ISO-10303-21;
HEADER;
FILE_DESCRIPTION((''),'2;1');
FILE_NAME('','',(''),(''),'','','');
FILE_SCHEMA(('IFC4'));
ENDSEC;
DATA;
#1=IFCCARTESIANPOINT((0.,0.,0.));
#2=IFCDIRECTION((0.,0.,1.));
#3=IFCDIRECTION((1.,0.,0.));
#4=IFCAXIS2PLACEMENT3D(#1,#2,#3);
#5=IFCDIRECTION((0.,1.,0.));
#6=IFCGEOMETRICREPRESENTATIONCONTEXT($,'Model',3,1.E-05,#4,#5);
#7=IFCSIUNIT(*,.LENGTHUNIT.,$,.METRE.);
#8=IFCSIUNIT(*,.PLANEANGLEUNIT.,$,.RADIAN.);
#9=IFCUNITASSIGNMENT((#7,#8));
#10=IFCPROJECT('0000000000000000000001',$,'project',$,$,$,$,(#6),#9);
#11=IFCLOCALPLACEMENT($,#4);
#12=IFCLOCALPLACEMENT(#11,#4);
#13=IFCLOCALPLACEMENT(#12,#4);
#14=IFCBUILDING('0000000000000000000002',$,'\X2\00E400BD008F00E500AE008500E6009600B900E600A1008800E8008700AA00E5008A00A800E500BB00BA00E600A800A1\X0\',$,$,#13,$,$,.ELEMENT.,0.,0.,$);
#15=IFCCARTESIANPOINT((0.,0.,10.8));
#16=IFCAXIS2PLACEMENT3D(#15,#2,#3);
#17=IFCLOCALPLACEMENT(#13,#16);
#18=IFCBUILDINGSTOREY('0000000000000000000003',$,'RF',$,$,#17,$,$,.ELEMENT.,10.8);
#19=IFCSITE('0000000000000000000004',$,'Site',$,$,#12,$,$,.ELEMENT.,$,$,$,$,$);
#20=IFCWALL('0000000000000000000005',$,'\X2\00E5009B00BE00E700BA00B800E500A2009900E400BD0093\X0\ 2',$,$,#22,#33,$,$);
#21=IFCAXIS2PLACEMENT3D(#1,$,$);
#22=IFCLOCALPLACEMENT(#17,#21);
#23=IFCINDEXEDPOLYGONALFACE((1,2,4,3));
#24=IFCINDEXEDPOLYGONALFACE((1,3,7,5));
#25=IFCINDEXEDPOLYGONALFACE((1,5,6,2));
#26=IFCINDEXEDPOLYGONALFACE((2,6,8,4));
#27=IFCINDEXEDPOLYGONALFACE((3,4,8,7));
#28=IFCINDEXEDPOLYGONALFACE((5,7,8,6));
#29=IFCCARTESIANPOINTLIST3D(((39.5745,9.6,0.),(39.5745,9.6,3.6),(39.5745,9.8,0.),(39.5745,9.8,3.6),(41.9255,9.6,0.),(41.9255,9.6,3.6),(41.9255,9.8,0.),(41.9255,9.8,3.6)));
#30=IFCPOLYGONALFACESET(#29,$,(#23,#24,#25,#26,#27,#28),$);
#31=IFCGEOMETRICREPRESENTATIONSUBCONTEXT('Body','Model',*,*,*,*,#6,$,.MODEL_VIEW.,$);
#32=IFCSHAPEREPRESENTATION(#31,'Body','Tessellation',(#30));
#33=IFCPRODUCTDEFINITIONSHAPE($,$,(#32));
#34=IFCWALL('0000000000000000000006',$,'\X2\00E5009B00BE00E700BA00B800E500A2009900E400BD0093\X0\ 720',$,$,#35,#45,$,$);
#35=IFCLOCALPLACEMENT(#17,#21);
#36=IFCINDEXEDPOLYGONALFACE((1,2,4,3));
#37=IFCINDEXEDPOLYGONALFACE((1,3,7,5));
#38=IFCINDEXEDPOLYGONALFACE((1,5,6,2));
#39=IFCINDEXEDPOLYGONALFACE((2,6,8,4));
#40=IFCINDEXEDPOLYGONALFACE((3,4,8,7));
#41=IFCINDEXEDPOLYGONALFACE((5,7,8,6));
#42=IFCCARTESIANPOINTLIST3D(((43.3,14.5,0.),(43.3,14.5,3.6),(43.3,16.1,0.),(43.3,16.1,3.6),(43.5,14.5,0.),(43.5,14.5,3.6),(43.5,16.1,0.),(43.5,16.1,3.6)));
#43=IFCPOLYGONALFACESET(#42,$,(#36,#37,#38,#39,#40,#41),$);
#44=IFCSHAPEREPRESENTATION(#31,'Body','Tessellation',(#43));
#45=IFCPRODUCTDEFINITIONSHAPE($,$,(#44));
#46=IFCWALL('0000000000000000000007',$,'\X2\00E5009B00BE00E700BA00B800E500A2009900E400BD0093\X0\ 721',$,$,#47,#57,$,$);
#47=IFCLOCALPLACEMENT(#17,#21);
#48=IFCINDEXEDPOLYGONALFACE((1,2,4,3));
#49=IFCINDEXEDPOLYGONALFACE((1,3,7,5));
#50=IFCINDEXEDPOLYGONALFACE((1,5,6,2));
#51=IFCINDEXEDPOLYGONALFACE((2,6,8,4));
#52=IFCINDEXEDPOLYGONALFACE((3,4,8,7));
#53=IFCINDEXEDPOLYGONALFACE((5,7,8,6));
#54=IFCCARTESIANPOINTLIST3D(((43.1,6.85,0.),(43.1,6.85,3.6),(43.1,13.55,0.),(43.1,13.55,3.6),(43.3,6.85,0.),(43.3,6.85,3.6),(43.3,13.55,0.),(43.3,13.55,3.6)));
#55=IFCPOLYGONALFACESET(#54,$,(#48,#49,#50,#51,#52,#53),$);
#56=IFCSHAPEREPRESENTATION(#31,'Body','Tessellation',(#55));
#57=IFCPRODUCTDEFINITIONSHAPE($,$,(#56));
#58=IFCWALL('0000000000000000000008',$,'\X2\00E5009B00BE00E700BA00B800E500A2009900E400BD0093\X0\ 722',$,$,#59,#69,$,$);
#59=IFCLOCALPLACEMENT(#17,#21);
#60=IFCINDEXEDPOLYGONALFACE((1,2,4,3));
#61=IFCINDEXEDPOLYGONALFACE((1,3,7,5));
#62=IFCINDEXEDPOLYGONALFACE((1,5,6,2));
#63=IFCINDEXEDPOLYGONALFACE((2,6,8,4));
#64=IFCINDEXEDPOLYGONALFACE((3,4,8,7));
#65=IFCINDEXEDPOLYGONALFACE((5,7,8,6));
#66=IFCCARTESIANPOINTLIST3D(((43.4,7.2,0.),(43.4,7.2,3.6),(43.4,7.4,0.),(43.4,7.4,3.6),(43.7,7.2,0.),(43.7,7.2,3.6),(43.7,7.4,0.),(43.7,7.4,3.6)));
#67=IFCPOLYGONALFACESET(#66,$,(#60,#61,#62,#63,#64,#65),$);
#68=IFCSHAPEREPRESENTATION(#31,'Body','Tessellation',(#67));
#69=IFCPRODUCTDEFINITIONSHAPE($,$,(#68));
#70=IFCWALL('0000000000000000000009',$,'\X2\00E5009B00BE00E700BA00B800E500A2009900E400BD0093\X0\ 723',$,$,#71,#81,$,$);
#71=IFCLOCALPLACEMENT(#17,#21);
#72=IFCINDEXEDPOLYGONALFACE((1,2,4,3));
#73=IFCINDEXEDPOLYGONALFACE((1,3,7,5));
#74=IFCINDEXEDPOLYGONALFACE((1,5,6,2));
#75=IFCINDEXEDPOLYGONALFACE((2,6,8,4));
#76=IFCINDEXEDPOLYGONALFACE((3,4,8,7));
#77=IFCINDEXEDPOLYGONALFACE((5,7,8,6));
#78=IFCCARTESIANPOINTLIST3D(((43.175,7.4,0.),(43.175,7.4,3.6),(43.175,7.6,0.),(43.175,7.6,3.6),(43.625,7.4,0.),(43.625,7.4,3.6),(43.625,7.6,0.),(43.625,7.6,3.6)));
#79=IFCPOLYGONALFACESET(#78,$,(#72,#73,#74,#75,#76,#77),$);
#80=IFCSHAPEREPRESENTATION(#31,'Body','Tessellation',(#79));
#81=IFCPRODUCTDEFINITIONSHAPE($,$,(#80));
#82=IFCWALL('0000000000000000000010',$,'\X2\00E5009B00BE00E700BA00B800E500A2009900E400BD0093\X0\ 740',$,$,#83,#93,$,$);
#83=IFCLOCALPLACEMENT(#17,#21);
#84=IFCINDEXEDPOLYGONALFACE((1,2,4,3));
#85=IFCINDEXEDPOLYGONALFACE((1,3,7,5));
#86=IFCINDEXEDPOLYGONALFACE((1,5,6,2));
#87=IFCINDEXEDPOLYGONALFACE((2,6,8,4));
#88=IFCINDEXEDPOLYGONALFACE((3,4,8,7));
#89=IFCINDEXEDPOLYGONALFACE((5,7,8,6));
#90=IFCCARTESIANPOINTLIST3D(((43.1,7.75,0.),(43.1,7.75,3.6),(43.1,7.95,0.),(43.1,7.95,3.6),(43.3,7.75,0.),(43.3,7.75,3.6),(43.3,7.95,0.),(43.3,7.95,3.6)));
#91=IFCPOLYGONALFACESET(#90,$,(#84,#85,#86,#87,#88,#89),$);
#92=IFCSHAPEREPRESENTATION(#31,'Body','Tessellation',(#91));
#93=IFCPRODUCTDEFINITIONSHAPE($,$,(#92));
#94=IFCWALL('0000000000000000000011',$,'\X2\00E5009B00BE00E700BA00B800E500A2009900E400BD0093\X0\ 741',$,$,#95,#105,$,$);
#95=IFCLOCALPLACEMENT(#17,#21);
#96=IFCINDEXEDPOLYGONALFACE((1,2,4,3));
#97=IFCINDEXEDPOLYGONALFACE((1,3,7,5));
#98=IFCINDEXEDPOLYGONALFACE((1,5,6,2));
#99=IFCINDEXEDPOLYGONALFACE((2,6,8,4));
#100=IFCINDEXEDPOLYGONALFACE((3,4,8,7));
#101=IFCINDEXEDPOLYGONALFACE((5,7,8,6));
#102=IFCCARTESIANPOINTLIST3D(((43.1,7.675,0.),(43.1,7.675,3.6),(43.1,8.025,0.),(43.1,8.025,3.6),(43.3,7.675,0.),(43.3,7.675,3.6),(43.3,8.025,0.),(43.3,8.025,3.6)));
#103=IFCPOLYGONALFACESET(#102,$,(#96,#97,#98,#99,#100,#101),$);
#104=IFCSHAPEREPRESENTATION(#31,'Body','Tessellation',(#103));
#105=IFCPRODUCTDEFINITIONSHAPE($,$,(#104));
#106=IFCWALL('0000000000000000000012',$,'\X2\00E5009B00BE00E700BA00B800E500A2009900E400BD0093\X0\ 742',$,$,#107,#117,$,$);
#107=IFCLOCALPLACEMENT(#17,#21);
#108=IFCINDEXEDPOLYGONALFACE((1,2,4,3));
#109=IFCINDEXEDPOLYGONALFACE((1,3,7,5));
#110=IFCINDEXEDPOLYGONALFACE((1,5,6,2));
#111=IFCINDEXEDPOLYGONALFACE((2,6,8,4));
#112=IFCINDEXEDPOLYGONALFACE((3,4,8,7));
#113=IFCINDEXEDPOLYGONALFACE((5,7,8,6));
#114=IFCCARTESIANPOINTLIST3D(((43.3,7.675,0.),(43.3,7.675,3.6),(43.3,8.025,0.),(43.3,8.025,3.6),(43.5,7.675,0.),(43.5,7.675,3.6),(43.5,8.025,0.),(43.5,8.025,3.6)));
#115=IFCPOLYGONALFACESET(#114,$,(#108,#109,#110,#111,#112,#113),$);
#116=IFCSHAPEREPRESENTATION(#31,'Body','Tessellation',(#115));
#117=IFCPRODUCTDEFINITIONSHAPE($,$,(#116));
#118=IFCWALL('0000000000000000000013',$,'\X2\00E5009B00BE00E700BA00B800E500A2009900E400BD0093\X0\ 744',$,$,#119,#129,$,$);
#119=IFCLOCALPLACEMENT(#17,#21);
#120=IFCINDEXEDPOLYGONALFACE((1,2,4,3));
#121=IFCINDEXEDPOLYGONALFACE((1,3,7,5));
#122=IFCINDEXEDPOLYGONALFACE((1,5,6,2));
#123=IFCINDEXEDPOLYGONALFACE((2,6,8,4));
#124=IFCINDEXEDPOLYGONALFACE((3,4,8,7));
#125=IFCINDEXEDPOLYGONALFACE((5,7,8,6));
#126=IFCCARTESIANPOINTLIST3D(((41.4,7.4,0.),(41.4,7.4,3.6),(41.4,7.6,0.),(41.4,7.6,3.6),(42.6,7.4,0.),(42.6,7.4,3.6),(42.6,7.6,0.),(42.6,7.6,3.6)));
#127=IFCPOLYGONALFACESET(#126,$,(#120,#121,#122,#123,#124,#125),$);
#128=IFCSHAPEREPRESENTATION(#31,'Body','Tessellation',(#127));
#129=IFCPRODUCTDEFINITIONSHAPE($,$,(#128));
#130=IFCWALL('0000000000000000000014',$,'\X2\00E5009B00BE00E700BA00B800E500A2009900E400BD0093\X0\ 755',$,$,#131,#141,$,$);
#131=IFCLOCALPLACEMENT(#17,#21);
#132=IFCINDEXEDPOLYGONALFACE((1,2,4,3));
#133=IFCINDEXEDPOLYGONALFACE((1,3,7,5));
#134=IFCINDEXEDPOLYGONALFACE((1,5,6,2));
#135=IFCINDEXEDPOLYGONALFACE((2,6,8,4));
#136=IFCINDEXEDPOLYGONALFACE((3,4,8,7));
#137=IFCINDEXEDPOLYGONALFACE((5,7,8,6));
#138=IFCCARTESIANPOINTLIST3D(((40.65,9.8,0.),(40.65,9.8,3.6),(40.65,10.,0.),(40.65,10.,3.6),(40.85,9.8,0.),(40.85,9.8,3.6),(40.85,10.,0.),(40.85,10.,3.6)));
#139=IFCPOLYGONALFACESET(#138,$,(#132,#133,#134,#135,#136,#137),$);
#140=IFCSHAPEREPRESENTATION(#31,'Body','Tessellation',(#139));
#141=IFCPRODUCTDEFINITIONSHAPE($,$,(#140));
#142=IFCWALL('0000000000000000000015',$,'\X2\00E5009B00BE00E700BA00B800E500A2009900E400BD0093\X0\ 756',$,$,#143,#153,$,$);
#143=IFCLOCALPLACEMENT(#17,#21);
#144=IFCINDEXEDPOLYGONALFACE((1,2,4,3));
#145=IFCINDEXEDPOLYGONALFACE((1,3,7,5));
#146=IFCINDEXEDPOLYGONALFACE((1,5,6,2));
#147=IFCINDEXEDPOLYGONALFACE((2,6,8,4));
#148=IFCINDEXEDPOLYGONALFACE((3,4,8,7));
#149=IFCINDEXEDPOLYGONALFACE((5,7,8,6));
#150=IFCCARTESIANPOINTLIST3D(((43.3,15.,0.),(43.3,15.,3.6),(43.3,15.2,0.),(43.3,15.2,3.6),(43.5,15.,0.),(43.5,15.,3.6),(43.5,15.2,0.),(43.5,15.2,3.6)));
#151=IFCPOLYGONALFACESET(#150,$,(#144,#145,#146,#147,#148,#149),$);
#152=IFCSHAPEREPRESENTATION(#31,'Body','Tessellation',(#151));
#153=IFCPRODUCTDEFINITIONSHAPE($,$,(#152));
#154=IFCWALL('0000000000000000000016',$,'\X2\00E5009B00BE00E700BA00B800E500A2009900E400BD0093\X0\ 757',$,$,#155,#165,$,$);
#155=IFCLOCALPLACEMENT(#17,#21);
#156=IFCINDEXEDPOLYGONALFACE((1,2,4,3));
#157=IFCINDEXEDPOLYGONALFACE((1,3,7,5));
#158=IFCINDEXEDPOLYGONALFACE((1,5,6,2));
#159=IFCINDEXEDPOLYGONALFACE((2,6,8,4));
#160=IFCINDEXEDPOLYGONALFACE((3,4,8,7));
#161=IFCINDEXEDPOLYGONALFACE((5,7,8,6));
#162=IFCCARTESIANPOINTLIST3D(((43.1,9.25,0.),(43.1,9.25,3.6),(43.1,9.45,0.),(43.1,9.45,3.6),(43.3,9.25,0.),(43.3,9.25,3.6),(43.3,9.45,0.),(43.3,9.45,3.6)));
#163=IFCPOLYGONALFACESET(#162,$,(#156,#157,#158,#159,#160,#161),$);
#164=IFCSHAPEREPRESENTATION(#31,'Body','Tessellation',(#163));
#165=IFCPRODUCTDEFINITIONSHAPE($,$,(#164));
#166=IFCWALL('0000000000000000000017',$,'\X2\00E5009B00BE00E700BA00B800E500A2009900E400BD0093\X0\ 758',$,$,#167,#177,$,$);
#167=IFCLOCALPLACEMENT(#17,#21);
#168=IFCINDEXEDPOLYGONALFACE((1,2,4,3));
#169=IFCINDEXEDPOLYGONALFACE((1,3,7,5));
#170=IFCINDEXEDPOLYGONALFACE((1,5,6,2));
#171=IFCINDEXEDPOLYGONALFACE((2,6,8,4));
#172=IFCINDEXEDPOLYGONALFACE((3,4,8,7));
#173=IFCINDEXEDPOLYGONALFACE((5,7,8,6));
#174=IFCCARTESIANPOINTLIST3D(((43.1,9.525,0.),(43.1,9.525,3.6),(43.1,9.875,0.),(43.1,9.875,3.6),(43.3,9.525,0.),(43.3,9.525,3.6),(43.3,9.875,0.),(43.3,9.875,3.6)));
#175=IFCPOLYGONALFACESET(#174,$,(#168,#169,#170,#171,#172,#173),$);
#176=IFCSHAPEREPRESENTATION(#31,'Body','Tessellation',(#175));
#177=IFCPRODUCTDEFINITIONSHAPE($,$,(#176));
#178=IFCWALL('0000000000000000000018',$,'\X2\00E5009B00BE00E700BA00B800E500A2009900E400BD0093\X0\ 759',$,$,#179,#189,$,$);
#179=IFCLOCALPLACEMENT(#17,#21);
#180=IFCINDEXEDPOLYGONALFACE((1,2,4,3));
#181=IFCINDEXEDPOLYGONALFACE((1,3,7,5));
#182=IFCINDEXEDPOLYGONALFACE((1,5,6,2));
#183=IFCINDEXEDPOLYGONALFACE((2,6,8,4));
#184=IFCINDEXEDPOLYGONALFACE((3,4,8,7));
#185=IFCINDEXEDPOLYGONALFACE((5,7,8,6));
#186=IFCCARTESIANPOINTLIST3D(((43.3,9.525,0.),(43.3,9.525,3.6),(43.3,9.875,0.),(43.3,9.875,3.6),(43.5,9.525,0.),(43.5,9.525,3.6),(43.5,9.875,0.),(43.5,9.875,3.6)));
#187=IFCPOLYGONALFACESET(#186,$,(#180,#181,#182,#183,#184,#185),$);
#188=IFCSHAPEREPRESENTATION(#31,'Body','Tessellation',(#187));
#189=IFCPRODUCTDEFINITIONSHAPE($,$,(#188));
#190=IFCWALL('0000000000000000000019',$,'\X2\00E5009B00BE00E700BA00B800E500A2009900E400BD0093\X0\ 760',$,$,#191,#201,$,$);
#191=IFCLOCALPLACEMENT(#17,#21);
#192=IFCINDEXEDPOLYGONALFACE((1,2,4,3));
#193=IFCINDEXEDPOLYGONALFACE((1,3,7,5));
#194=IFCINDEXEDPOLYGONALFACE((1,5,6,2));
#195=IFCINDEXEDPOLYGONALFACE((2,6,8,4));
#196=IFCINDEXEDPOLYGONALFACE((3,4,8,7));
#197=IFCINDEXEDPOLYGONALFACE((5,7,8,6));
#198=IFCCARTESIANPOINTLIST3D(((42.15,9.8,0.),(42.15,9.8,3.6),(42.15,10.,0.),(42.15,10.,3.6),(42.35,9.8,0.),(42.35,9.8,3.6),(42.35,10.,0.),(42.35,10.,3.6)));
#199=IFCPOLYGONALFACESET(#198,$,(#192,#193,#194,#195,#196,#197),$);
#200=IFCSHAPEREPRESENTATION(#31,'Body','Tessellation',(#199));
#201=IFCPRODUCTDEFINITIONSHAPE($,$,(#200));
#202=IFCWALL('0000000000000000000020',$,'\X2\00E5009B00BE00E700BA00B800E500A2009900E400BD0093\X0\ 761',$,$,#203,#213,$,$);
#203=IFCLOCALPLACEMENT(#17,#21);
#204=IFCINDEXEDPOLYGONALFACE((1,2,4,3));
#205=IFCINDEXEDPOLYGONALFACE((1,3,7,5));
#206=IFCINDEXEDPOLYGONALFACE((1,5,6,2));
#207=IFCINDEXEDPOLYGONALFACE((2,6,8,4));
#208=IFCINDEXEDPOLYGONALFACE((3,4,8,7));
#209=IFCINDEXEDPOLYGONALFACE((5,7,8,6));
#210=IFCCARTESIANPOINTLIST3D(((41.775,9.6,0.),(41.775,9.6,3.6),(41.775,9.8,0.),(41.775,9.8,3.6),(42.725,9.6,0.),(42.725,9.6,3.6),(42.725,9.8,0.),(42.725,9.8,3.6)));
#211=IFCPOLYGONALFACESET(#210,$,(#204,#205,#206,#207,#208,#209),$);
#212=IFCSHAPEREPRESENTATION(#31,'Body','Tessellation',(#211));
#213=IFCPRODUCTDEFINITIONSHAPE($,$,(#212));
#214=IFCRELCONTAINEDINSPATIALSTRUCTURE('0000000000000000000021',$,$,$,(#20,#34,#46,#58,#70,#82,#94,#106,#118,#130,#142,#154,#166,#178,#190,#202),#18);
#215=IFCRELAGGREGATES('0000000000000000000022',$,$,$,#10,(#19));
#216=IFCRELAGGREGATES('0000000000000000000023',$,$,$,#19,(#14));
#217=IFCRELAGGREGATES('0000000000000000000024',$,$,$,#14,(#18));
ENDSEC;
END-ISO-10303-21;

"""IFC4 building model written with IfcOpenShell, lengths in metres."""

from ifc_helpers import new_model, si_unit, direction, frame, frame_2d, origin_with_axes, place, context, subcontext, project, spatial, rectangle, extrude, element, save


model = new_model("IFC4")

# Units and contexts
model_context = context("Model", 3, precision=1e-05, world=origin_with_axes(), true_north=direction((0.0, 1.0, 0.0)))
body_context = subcontext(model_context, "Body", "Model", "MODEL_VIEW")
ifc_project = project(units=[si_unit("LENGTHUNIT", "METRE"), si_unit("PLANEANGLEUNIT", "RADIAN")], contexts=[model_context])

# Site, building, storey
placement = place(None, origin_with_axes())
site_placement = place(placement, origin_with_axes())
site = spatial("IfcSite", under=ifc_project, at=site_placement, Name="Site", CompositionType="ELEMENT")
building_placement = place(site_placement, origin_with_axes())
building = spatial("IfcBuilding", under=site, at=building_placement, Name="ä½\u008få®\u0085æ\u0096¹æ¡\u0088è\u0087ªå\u008a¨å»ºæ¨¡", CompositionType="ELEMENT", ElevationOfRefHeight=0.0, ElevationOfTerrain=0.0)
storey_placement = place(building_placement, frame((0.0, 0.0, 10.8), z_axis=(0.0, 0.0, 1.0), x_axis=(1.0, 0.0, 0.0)))
storey = spatial("IfcBuildingStorey", under=building, at=storey_placement, Name="RF", CompositionType="ELEMENT", Elevation=10.8)

# Walls
wall_1_placement = place(storey_placement, frame((40.75, 9.7, 0.0), z_axis=(0.0, 0.0, 1.0), x_axis=(-1.0, 0.0, 0.0)))
element("IfcWall", 1, at=wall_1_placement, inside=storey, Name="å\u009b¾çº¸å¢\u0099ä½\u0093 2", context=body_context, shape_type="SweptSolid", body=[
    extrude(rectangle(XDim=2.351, YDim=0.2, at=frame_2d((0.0, 0.0), x_axis=(1.0, 0.0, 0.0))), frame((0.0, 0.0, 0.0), z_axis=(0.0, 0.0, 1.0)), (0.0, 0.0, 1.0), 3.6),
])
wall_2_placement = place(storey_placement, frame((43.4, 15.3, 0.0), z_axis=(0.0, 0.0, 1.0), x_axis=(0.0, 1.0, 0.0)))
element("IfcWall", 2, at=wall_2_placement, inside=storey, Name="å\u009b¾çº¸å¢\u0099ä½\u0093 720", context=body_context, shape_type="SweptSolid", body=[
    extrude(rectangle(XDim=1.6, YDim=0.2, at=frame_2d((0.0, 0.0), x_axis=(1.0, 0.0, 0.0))), frame((0.0, 0.0, 0.0), z_axis=(0.0, 0.0, 1.0)), (0.0, 0.0, 1.0), 3.6),
])
wall_3_placement = place(storey_placement, frame((43.2, 10.2, 0.0), z_axis=(0.0, 0.0, 1.0), x_axis=(0.0, 1.0, 0.0)))
element("IfcWall", 3, at=wall_3_placement, inside=storey, Name="å\u009b¾çº¸å¢\u0099ä½\u0093 721", context=body_context, shape_type="SweptSolid", body=[
    extrude(rectangle(XDim=6.7, YDim=0.2, at=frame_2d((0.0, 0.0), x_axis=(1.0, 0.0, 0.0))), frame((0.0, 0.0, 0.0), z_axis=(0.0, 0.0, 1.0)), (0.0, 0.0, 1.0), 3.6),
])
wall_4_placement = place(storey_placement, frame((43.55, 7.3, 0.0), z_axis=(0.0, 0.0, 1.0), x_axis=(1.0, 0.0, 0.0)))
element("IfcWall", 4, at=wall_4_placement, inside=storey, Name="å\u009b¾çº¸å¢\u0099ä½\u0093 722", context=body_context, shape_type="SweptSolid", body=[
    extrude(rectangle(XDim=0.3, YDim=0.2, at=frame_2d((0.0, 0.0), x_axis=(1.0, 0.0, 0.0))), frame((0.0, 0.0, 0.0), z_axis=(0.0, 0.0, 1.0)), (0.0, 0.0, 1.0), 3.6),
])
wall_5_placement = place(storey_placement, frame((43.4, 7.5, 0.0), z_axis=(0.0, 0.0, 1.0), x_axis=(1.0, 0.0, 0.0)))
element("IfcWall", 5, at=wall_5_placement, inside=storey, Name="å\u009b¾çº¸å¢\u0099ä½\u0093 723", context=body_context, shape_type="SweptSolid", body=[
    extrude(rectangle(XDim=0.45, YDim=0.2, at=frame_2d((0.0, 0.0), x_axis=(1.0, 0.0, 0.0))), frame((0.0, 0.0, 0.0), z_axis=(0.0, 0.0, 1.0)), (0.0, 0.0, 1.0), 3.6),
])
wall_6_placement = place(storey_placement, frame((43.2, 7.85, 0.0), z_axis=(0.0, 0.0, 1.0), x_axis=(1.0, 0.0, 0.0)))
element("IfcWall", 6, at=wall_6_placement, inside=storey, Name="å\u009b¾çº¸å¢\u0099ä½\u0093 740", context=body_context, shape_type="SweptSolid", body=[
    extrude(rectangle(XDim=0.2, YDim=0.2, at=frame_2d((0.0, 0.0), x_axis=(1.0, 0.0, 0.0))), frame((0.0, 0.0, 0.0), z_axis=(0.0, 0.0, 1.0)), (0.0, 0.0, 1.0), 3.6),
])
for number, where, z_axis, x_axis, name in (
    (7, (43.2, 7.85, 0.0), (0.0, 0.0, 1.0), (0.0, -1.0, 0.0), "å\u009b¾çº¸å¢\u0099ä½\u0093 741"),
    (8, (43.4, 7.85, 0.0), (0.0, 0.0, 1.0), (0.0, -1.0, 0.0), "å\u009b¾çº¸å¢\u0099ä½\u0093 742"),
):
    element("IfcWall", number, at=place(storey_placement, frame(where, z_axis=z_axis, x_axis=x_axis)), inside=storey, Name=name, context=body_context, shape_type="SweptSolid", body=[
        extrude(rectangle(XDim=0.35, YDim=0.2, at=frame_2d((0.0, 0.0), x_axis=(1.0, 0.0, 0.0))), frame((0.0, 0.0, 0.0), z_axis=(0.0, 0.0, 1.0)), (0.0, 0.0, 1.0), 3.6),
    ])
wall_7_placement = place(storey_placement, frame((42.0, 7.5, 0.0), z_axis=(0.0, 0.0, 1.0), x_axis=(1.0, 0.0, 0.0)))
element("IfcWall", 9, at=wall_7_placement, inside=storey, Name="å\u009b¾çº¸å¢\u0099ä½\u0093 744", context=body_context, shape_type="SweptSolid", body=[
    extrude(rectangle(XDim=1.2, YDim=0.2, at=frame_2d((0.0, 0.0), x_axis=(1.0, 0.0, 0.0))), frame((0.0, 0.0, 0.0), z_axis=(0.0, 0.0, 1.0)), (0.0, 0.0, 1.0), 3.6),
])
for number, where, z_axis, x_axis, name in (
    (10, (40.75, 9.9, 0.0), (0.0, 0.0, 1.0), (0.0, -1.0, 0.0), "å\u009b¾çº¸å¢\u0099ä½\u0093 755"),
    (11, (43.4, 15.1, 0.0), (0.0, 0.0, 1.0), (0.0, 1.0, 0.0), "å\u009b¾çº¸å¢\u0099ä½\u0093 756"),
    (12, (43.2, 9.35, 0.0), (0.0, 0.0, 1.0), (1.0, 0.0, 0.0), "å\u009b¾çº¸å¢\u0099ä½\u0093 757"),
):
    element("IfcWall", number, at=place(storey_placement, frame(where, z_axis=z_axis, x_axis=x_axis)), inside=storey, Name=name, context=body_context, shape_type="SweptSolid", body=[
        extrude(rectangle(XDim=0.2, YDim=0.2, at=frame_2d((0.0, 0.0), x_axis=(1.0, 0.0, 0.0))), frame((0.0, 0.0, 0.0), z_axis=(0.0, 0.0, 1.0)), (0.0, 0.0, 1.0), 3.6),
    ])
for number, where, z_axis, x_axis, name in (
    (13, (43.2, 9.7, 0.0), (0.0, 0.0, 1.0), (0.0, -1.0, 0.0), "å\u009b¾çº¸å¢\u0099ä½\u0093 758"),
    (14, (43.4, 9.7, 0.0), (0.0, 0.0, 1.0), (0.0, -1.0, 0.0), "å\u009b¾çº¸å¢\u0099ä½\u0093 759"),
):
    element("IfcWall", number, at=place(storey_placement, frame(where, z_axis=z_axis, x_axis=x_axis)), inside=storey, Name=name, context=body_context, shape_type="SweptSolid", body=[
        extrude(rectangle(XDim=0.35, YDim=0.2, at=frame_2d((0.0, 0.0), x_axis=(1.0, 0.0, 0.0))), frame((0.0, 0.0, 0.0), z_axis=(0.0, 0.0, 1.0)), (0.0, 0.0, 1.0), 3.6),
    ])
wall_8_placement = place(storey_placement, frame((42.25, 9.9, 0.0), z_axis=(0.0, 0.0, 1.0), x_axis=(0.0, -1.0, 0.0)))
element("IfcWall", 15, at=wall_8_placement, inside=storey, Name="å\u009b¾çº¸å¢\u0099ä½\u0093 760", context=body_context, shape_type="SweptSolid", body=[
    extrude(rectangle(XDim=0.2, YDim=0.2, at=frame_2d((0.0, 0.0), x_axis=(1.0, 0.0, 0.0))), frame((0.0, 0.0, 0.0), z_axis=(0.0, 0.0, 1.0)), (0.0, 0.0, 1.0), 3.6),
])
wall_9_placement = place(storey_placement, frame((42.25, 9.7, 0.0), z_axis=(0.0, 0.0, 1.0), x_axis=(1.0, 0.0, 0.0)))
element("IfcWall", 16, at=wall_9_placement, inside=storey, Name="å\u009b¾çº¸å¢\u0099ä½\u0093 761", context=body_context, shape_type="SweptSolid", body=[
    extrude(rectangle(XDim=0.95, YDim=0.2, at=frame_2d((0.0, 0.0), x_axis=(1.0, 0.0, 0.0))), frame((0.0, 0.0, 0.0), z_axis=(0.0, 0.0, 1.0)), (0.0, 0.0, 1.0), 3.6),
])

save(model, "model.ifc")
